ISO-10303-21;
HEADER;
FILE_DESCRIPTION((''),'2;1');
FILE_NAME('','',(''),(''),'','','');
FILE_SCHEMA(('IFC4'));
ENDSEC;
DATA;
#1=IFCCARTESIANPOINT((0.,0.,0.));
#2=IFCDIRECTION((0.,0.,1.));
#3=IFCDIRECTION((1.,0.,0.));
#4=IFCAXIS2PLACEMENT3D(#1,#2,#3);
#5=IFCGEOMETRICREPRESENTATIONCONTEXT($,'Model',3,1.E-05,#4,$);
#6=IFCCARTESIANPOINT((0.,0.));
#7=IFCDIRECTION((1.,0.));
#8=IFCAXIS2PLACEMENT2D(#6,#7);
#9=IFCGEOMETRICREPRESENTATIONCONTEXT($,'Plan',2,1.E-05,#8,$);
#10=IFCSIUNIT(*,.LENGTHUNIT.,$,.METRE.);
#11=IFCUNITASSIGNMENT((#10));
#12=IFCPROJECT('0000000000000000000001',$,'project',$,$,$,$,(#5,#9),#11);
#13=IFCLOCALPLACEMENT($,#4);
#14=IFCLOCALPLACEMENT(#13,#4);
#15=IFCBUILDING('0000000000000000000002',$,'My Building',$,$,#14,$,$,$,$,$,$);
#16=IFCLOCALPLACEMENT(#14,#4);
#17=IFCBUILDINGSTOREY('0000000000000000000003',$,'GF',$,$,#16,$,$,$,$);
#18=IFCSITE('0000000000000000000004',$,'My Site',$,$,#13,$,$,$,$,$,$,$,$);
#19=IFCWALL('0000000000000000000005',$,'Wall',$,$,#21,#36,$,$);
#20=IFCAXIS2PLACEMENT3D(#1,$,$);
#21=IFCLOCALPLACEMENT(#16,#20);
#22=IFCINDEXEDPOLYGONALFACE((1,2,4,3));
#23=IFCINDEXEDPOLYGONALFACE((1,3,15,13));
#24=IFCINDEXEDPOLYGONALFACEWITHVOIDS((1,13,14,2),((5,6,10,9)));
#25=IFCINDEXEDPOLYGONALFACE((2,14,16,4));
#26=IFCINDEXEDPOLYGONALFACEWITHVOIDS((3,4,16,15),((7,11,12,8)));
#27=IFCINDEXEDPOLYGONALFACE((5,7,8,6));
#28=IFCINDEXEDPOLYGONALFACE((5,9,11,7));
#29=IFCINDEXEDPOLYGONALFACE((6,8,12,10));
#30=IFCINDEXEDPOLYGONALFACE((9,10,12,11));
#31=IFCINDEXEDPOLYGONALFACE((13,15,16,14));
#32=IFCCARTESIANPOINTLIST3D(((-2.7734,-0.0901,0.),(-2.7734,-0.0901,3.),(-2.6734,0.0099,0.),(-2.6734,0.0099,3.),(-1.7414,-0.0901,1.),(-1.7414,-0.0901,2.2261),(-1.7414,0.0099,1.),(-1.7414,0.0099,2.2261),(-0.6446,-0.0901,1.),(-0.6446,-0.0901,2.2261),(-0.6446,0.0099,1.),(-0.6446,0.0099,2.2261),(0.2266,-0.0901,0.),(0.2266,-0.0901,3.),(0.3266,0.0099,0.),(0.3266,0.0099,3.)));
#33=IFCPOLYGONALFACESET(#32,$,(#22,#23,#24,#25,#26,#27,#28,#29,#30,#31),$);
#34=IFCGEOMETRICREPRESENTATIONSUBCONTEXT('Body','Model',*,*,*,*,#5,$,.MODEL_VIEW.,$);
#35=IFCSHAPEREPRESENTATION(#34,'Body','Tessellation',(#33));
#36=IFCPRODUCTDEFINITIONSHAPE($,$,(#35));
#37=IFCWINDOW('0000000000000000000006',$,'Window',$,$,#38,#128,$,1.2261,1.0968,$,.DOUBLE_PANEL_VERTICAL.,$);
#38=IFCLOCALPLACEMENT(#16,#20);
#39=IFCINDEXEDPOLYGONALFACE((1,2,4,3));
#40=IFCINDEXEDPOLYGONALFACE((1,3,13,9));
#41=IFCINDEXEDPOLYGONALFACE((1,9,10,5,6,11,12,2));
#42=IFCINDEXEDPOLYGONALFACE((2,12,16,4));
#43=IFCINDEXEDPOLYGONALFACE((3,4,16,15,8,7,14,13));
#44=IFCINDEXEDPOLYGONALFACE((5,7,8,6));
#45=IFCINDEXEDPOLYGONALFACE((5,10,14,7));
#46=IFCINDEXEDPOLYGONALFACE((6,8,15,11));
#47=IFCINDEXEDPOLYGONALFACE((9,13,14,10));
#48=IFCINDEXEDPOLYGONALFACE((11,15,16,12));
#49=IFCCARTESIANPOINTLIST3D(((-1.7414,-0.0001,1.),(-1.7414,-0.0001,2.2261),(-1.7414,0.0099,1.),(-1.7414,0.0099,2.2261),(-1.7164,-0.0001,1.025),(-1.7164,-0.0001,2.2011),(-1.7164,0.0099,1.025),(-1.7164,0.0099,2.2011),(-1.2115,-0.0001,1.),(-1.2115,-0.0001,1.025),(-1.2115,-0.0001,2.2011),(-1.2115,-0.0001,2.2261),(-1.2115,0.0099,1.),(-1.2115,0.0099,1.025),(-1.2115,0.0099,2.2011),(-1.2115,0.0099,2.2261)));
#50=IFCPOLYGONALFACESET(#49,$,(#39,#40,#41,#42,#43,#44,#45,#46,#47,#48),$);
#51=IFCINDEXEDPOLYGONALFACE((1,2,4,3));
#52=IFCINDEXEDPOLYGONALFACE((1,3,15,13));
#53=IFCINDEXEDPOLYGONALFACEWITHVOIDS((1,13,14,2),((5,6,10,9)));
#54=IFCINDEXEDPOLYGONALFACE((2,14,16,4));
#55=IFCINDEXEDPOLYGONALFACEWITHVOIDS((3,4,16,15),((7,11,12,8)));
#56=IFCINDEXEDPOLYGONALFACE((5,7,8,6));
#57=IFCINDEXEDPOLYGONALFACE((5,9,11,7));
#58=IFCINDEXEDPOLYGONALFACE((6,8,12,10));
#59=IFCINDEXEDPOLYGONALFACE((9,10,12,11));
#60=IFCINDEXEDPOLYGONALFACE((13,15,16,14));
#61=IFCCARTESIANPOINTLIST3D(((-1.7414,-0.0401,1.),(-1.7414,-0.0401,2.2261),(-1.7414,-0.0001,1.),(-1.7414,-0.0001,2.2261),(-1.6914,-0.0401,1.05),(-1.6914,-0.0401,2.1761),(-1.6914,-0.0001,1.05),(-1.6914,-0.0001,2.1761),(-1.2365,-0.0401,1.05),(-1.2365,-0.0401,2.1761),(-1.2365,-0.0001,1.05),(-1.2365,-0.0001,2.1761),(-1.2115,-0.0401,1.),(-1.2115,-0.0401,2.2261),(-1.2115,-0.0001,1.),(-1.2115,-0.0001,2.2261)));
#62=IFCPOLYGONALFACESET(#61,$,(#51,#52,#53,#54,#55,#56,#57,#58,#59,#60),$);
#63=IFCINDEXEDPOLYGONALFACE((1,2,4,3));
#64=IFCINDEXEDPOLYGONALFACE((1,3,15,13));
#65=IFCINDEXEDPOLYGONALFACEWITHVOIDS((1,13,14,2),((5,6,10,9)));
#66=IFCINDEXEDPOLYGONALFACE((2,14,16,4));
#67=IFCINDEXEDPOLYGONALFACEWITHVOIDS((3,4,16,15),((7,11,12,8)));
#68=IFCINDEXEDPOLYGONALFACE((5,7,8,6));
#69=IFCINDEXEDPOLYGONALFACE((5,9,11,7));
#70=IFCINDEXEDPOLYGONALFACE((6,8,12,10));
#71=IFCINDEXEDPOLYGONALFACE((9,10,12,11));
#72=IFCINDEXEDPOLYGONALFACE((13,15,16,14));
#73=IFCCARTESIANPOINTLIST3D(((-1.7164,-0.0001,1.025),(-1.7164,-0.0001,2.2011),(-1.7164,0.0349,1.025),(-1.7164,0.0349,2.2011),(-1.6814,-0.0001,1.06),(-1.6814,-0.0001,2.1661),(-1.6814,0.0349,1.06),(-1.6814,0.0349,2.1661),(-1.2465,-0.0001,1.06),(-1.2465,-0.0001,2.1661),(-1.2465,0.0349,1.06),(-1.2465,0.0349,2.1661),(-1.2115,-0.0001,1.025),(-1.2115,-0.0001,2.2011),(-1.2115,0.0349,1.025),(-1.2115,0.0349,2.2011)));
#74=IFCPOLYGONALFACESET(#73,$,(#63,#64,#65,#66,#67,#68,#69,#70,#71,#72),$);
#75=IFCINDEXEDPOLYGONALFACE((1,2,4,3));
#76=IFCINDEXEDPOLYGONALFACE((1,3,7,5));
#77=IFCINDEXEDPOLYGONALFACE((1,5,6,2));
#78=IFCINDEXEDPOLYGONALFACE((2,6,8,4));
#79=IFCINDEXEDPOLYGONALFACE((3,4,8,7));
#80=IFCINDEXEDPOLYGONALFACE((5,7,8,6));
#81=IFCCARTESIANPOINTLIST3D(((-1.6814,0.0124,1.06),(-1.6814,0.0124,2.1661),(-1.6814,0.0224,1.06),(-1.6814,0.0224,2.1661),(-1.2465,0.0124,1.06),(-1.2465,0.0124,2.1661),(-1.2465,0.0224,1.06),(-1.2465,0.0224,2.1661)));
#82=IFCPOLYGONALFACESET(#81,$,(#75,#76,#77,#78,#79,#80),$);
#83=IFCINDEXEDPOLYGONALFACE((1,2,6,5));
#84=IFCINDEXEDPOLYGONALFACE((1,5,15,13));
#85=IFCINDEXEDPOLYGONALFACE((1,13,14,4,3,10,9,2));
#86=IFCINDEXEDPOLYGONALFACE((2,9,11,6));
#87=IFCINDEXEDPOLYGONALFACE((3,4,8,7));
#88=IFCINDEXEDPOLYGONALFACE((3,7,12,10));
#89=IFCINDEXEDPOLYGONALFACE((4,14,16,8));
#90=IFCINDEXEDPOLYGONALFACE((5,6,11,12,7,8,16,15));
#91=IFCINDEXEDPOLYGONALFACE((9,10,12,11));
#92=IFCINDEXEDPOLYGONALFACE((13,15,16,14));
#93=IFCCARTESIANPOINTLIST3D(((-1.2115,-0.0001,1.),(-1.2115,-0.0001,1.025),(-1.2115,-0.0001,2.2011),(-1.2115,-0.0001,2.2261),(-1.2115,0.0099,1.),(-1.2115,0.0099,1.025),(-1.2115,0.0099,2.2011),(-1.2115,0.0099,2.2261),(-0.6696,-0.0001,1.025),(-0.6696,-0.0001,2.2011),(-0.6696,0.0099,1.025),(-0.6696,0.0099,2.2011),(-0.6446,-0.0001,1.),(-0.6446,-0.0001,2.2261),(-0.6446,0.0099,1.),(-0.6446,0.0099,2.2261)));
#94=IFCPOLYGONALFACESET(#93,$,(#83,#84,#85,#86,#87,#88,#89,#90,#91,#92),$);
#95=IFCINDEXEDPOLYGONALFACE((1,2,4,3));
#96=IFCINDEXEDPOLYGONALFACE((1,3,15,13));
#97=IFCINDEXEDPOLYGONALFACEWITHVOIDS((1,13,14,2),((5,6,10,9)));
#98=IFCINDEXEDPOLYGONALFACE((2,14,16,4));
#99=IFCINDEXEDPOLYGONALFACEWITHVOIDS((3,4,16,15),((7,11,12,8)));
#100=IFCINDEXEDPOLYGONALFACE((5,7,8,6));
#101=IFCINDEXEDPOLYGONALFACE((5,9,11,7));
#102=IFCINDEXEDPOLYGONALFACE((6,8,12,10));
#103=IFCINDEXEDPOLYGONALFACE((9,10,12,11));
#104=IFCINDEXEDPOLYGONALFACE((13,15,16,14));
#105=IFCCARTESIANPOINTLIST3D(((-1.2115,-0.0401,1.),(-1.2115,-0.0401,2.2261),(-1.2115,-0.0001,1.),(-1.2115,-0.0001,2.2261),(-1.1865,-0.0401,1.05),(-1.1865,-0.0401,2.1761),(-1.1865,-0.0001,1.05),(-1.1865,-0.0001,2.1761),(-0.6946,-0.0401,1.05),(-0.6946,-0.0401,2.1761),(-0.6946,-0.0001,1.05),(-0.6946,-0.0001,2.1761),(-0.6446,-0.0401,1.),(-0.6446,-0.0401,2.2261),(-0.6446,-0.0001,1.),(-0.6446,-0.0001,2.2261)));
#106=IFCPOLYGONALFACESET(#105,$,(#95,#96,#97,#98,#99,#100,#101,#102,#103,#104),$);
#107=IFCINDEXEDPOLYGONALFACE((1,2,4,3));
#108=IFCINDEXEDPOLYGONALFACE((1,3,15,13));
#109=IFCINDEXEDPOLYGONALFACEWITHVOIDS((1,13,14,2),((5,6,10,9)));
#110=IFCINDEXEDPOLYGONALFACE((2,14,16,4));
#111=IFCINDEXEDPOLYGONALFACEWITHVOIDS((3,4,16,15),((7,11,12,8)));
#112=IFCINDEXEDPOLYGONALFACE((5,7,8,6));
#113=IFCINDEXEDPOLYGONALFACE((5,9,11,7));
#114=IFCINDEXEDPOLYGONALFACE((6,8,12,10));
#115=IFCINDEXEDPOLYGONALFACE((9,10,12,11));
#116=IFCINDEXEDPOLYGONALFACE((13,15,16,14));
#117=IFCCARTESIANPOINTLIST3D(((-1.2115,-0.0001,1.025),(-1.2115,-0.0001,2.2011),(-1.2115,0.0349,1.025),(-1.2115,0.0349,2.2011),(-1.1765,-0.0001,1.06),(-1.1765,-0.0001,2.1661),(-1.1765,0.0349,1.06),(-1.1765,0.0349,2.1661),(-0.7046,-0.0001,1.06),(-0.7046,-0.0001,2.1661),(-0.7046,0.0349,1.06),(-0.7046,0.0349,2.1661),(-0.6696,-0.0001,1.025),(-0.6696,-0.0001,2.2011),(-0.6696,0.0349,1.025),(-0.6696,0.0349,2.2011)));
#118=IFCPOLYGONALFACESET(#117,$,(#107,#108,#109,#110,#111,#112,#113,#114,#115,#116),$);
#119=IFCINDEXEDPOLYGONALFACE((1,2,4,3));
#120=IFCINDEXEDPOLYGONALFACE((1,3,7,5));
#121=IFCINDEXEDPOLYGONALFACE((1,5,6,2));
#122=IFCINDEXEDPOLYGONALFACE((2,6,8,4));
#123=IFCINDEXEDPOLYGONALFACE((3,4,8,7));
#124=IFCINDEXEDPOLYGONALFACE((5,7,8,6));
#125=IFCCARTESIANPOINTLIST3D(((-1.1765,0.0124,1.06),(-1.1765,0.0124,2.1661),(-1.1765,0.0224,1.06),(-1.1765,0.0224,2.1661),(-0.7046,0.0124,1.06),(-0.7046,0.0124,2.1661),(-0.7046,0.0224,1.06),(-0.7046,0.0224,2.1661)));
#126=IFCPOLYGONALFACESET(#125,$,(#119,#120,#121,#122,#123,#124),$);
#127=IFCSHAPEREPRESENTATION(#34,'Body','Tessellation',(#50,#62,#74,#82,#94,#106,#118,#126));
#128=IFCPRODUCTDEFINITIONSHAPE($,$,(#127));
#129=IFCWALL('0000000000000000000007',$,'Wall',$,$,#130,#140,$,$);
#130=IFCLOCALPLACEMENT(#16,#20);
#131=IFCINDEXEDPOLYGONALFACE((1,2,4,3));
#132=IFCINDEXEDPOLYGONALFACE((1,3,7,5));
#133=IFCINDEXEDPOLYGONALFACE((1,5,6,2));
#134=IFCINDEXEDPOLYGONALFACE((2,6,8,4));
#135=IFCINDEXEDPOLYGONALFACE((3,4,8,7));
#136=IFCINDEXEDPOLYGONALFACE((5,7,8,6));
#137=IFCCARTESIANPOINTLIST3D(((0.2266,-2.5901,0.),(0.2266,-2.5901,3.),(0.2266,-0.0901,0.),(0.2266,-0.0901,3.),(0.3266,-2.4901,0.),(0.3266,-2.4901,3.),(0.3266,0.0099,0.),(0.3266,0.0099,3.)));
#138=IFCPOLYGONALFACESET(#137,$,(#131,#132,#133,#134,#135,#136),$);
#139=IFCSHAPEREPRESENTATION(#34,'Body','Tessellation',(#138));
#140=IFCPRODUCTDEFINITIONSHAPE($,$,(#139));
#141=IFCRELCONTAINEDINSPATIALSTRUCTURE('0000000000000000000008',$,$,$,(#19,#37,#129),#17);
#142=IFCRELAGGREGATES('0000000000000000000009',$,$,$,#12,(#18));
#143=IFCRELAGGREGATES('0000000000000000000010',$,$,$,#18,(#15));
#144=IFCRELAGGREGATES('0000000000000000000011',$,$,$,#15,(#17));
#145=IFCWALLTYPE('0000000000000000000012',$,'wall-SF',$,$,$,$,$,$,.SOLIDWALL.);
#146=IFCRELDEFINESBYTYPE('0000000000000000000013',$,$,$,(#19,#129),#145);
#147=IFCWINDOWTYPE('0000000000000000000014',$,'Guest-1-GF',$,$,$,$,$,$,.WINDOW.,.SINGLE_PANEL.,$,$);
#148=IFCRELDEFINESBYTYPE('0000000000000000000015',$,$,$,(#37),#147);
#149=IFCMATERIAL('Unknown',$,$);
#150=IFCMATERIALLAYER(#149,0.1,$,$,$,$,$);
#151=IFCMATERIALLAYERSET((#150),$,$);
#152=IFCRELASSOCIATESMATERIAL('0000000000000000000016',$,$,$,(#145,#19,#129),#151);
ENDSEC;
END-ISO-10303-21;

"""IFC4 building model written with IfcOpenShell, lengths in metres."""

from ifc_helpers import new_model, entity, si_unit, frame, origin_with_axes, origin_2d_with_axis, place, context, subcontext, project, spatial, line, indexed_curve, outline, extrude, shape, source, transform, mapped, material, layer, layer_set, layer_usage, type_object, type_shapes, element, fill, save


model = new_model("IFC4")

# Units and contexts
model_context = context("Model", 3, precision=1e-05, world=origin_with_axes())
plan_context = context("Plan", 2, precision=1e-05, world=origin_2d_with_axis())
body_context_1 = subcontext(model_context, "Body", "Model", "MODEL_VIEW")
body_context_2 = subcontext(plan_context, "Body", "Plan", "PLAN_VIEW")
ifc_project = project(units=[si_unit("LENGTHUNIT", "METRE")], contexts=[model_context, plan_context])

# Site, building, storey
site_placement = place(None, origin_with_axes())
site = spatial("IfcSite", under=ifc_project, at=site_placement, Name="My Site")
building_placement = place(site_placement, origin_with_axes())
building = spatial("IfcBuilding", under=site, at=building_placement, Name="My Building")
storey_placement = place(building_placement, origin_with_axes())
storey = spatial("IfcBuildingStorey", under=building, at=storey_placement, Name="GF")

# Shared definitions
ifc_material = material(Name="Unknown")

# Shared definitions
ifc_layer_1 = layer(ifc_material, 0.1)
ifc_layer_set_1 = layer_set([ifc_layer_1])
wall_type = type_object("IfcWallType", Name="wall-SF", PredefinedType="SOLIDWALL", material=ifc_layer_set_1)

# Wall, opening, window
ifc_layer_usage_1 = layer_usage(ifc_layer_set_1, "AXIS2", "POSITIVE", 0.0)
wall_1_placement = place(storey_placement, frame((-2.7734, -0.0901, 0.0), z_axis=(0.0, 0.0, 1.0), x_axis=(1.0, 0.0, 0.0)))
wall_1 = element("IfcWall", 1, at=wall_1_placement, inside=storey, type_object=wall_type, material=ifc_layer_usage_1, Name="Wall", context=body_context_1, shape_type="SweptSolid", body=[
    extrude(outline(indexed_curve([(0.0, 0.0), (0.1, 0.1), (3.1, 0.1), (3.0, 0.0)], segments=[line(1, 2, 3, 4, 1)])), origin_with_axes(), (0.0, 0.0, 1.0), 3.0),
])
shared_shape_1 = source(origin_with_axes(), body_context_1, "Body", "SweptSolid", [
    extrude(outline(indexed_curve([(0.0, 0.0), (1.0968, 0.0), (1.0968, 1.2261), (0.0, 1.2261)], segments=[line(1, 2, 3, 4, 1)])), frame((0.0, -0.6, 0.0), z_axis=(0.0, -1.0, 0.0), x_axis=(1.0, 0.0, 0.0)), (0.0, 0.0, -1.0), 1.2),
])
opening_1_placement = place(wall_1_placement, frame((1.032, 0.0, 1.0), z_axis=(0.0, 0.0, 1.0), x_axis=(1.0, 0.0, 0.0)))
opening_1 = element("IfcOpeningElement", 2, at=opening_1_placement, cuts=wall_1, PredefinedType="OPENING", context=body_context_1, shape_type="MappedRepresentation", body=[
    mapped(shared_shape_1, transform((0.0, 0.0, 0.0), x_axis=(1.0, 0.0, 0.0), y_axis=(0.0, 1.0, 0.0), z_axis=(0.0, 0.0, 1.0), scale=1.0)),
])
window_type_1 = type_object("IfcWindowType", Name="Guest-1-GF", PartitioningType="SINGLE_PANEL", PredefinedType="WINDOW")
shared_shape_2 = source(origin_with_axes(), body_context_1, "Body", "SweptSolid", [
    extrude(outline(indexed_curve([(0.5299, 0.0), (0.0, 0.0), (0.0, 1.2261), (0.5299, 1.2261), (0.5299, 1.2011), (0.025, 1.2011), (0.025, 0.025), (0.5299, 0.025)], segments=[line(1, 2, 3, 4, 5, 6, 7, 8, 1)])), frame((0.0, 0.09, 0.0), z_axis=(0.0, -1.0, 0.0), x_axis=(1.0, 0.0, 0.0)), (0.0, 0.0, -1.0), 0.01),
    extrude(outline(indexed_curve([(0.0, 0.0), (0.5299, 0.0), (0.5299, 1.2261), (0.0, 1.2261)], segments=[line(1, 2, 3, 4, 1)]), holes=[indexed_curve([(0.05, 0.05), (0.5049, 0.05), (0.5049, 1.1761), (0.05, 1.1761)], segments=[line(1, 2, 3, 4, 1)])]), frame((0.0, 0.05, 0.0), z_axis=(0.0, -1.0, 0.0), x_axis=(1.0, 0.0, 0.0)), (0.0, 0.0, -1.0), 0.04),
    extrude(outline(indexed_curve([(0.0, 0.0), (0.5049, 0.0), (0.5049, 1.1761), (0.0, 1.1761)], segments=[line(1, 2, 3, 4, 1)]), holes=[indexed_curve([(0.035, 0.035), (0.4699, 0.035), (0.4699, 1.1411), (0.035, 1.1411)], segments=[line(1, 2, 3, 4, 1)])]), frame((0.025, 0.09, 0.025), z_axis=(0.0, -1.0, 0.0), x_axis=(1.0, 0.0, 0.0)), (0.0, 0.0, -1.0), 0.035),
    extrude(outline(indexed_curve([(0.035, 0.035), (0.4699, 0.035), (0.4699, 1.1411), (0.035, 1.1411)], segments=[line(1, 2, 3, 4, 1)])), frame((0.025, 0.1025, 0.025), z_axis=(0.0, -1.0, 0.0), x_axis=(1.0, 0.0, 0.0)), (0.0, 0.0, -1.0), 0.01),
    extrude(outline(indexed_curve([(0.0, 1.2261), (0.5669, 1.2261), (0.5669, 0.0), (0.0, 0.0), (0.0, 0.025), (0.5419, 0.025), (0.5419, 1.2011), (0.0, 1.2011)], segments=[line(1, 2, 3, 4, 5, 6, 7, 8, 1)])), frame((0.5299, 0.09, 0.0), z_axis=(0.0, -1.0, 0.0), x_axis=(1.0, 0.0, 0.0)), (0.0, 0.0, -1.0), 0.01),
    extrude(outline(indexed_curve([(0.0, 0.0), (0.5669, 0.0), (0.5669, 1.2261), (0.0, 1.2261)], segments=[line(1, 2, 3, 4, 1)]), holes=[indexed_curve([(0.025, 0.05), (0.5169, 0.05), (0.5169, 1.1761), (0.025, 1.1761)], segments=[line(1, 2, 3, 4, 1)])]), frame((0.5299, 0.05, 0.0), z_axis=(0.0, -1.0, 0.0), x_axis=(1.0, 0.0, 0.0)), (0.0, 0.0, -1.0), 0.04),
    extrude(outline(indexed_curve([(0.0, 0.0), (0.5419, 0.0), (0.5419, 1.1761), (0.0, 1.1761)], segments=[line(1, 2, 3, 4, 1)]), holes=[indexed_curve([(0.035, 0.035), (0.5069, 0.035), (0.5069, 1.1411), (0.035, 1.1411)], segments=[line(1, 2, 3, 4, 1)])]), frame((0.5299, 0.09, 0.025), z_axis=(0.0, -1.0, 0.0), x_axis=(1.0, 0.0, 0.0)), (0.0, 0.0, -1.0), 0.035),
    extrude(outline(indexed_curve([(0.035, 0.035), (0.5069, 0.035), (0.5069, 1.1411), (0.035, 1.1411)], segments=[line(1, 2, 3, 4, 1)])), frame((0.5299, 0.1025, 0.025), z_axis=(0.0, -1.0, 0.0), x_axis=(1.0, 0.0, 0.0)), (0.0, 0.0, -1.0), 0.01),
])
shared_shape_3 = source(origin_with_axes(), body_context_2, "Body", "Curve2D", [
    entity("IfcIndexedPolyCurve", entity("IfcCartesianPointList2D", [[0.05, 0.05], [0.5049, 0.05]])),
    entity("IfcIndexedPolyCurve", entity("IfcCartesianPointList2D", [[0.0, 0.1], [0.025, 0.1], [0.025, 0.09], [0.05, 0.09], [0.05, 0.05], [0.0, 0.05]]), [entity("IfcLineIndex", [1, 2, 3, 4, 5, 6, 1])]),
    entity("IfcIndexedPolyCurve", entity("IfcCartesianPointList2D", [[0.5299, 0.1], [0.5299, 0.1], [0.5299, 0.09], [0.5049, 0.09], [0.5049, 0.05], [0.5299, 0.05]])),
    entity("IfcIndexedPolyCurve", entity("IfcCartesianPointList2D", [[0.025, 0.09], [0.06, 0.09], [0.06, 0.125], [0.025, 0.125]]), [entity("IfcLineIndex", [1, 2, 3, 4, 1])]),
    entity("IfcIndexedPolyCurve", entity("IfcCartesianPointList2D", [[0.5299, 0.09], [0.4949, 0.09], [0.4949, 0.125], [0.5299, 0.125]]), [entity("IfcLineIndex", [1, 2, 3, 4, 1])]),
    entity("IfcIndexedPolyCurve", entity("IfcCartesianPointList2D", [[0.06, 0.09], [0.4949, 0.09]])),
    entity("IfcIndexedPolyCurve", entity("IfcCartesianPointList2D", [[0.06, 0.125], [0.4949, 0.125]])),
    entity("IfcIndexedPolyCurve", entity("IfcCartesianPointList2D", [[0.06, 0.1075], [0.4949, 0.1075]])),
    entity("IfcIndexedPolyCurve", entity("IfcCartesianPointList2D", [[0.5549, 0.05], [1.0468, 0.05]])),
    entity("IfcIndexedPolyCurve", entity("IfcCartesianPointList2D", [[0.5299, 0.1], [0.5299, 0.1], [0.5299, 0.09], [0.5549, 0.09], [0.5549, 0.05], [0.5299, 0.05]])),
    entity("IfcIndexedPolyCurve", entity("IfcCartesianPointList2D", [[1.0968, 0.1], [1.0718, 0.1], [1.0718, 0.09], [1.0468, 0.09], [1.0468, 0.05], [1.0968, 0.05]]), [entity("IfcLineIndex", [1, 2, 3, 4, 5, 6, 1])]),
    entity("IfcIndexedPolyCurve", entity("IfcCartesianPointList2D", [[0.5299, 0.09], [0.5649, 0.09], [0.5649, 0.125], [0.5299, 0.125]]), [entity("IfcLineIndex", [1, 2, 3, 4, 1])]),
    entity("IfcIndexedPolyCurve", entity("IfcCartesianPointList2D", [[1.0718, 0.09], [1.0368, 0.09], [1.0368, 0.125], [1.0718, 0.125]]), [entity("IfcLineIndex", [1, 2, 3, 4, 1])]),
    entity("IfcIndexedPolyCurve", entity("IfcCartesianPointList2D", [[0.5649, 0.09], [1.0368, 0.09]])),
    entity("IfcIndexedPolyCurve", entity("IfcCartesianPointList2D", [[0.5649, 0.125], [1.0368, 0.125]])),
    entity("IfcIndexedPolyCurve", entity("IfcCartesianPointList2D", [[0.5649, 0.1075], [1.0368, 0.1075]])),
])
type_shapes(window_type_1, [shared_shape_2, shared_shape_3])
window_1_placement = place(opening_1_placement, origin_with_axes())
window_1 = element("IfcWindow", 3, at=window_1_placement, inside=storey, type_object=window_type_1, Name="Window", OverallHeight=1.2261, OverallWidth=1.0968, PartitioningType="DOUBLE_PANEL_VERTICAL", shapes=[
    shape(body_context_1, "Body", "MappedRepresentation", [mapped(shared_shape_2, transform((0.0, 0.0, 0.0), x_axis=(1.0, 0.0, 0.0), y_axis=(0.0, 1.0, 0.0), z_axis=(0.0, 0.0, 1.0), scale=1.0))]),
    shape(body_context_2, "Body", "MappedRepresentation", [mapped(shared_shape_3, transform((0.0, 0.0, 0.0), x_axis=(1.0, 0.0, 0.0), y_axis=(0.0, 1.0, 0.0), z_axis=(0.0, 0.0, 1.0), scale=1.0))]),
])
fill(opening_1, window_1)

# Wall
ifc_layer_usage_2 = layer_usage(ifc_layer_set_1, "AXIS2", "POSITIVE", 0.0)
wall_2_placement = place(storey_placement, frame((0.2266, -0.0901, 0.0), z_axis=(0.0, 0.0, 1.0), x_axis=(-0.000001, -1.0, 0.0)))
element("IfcWall", 4, at=wall_2_placement, inside=storey, type_object=wall_type, material=ifc_layer_usage_2, Name="Wall", context=body_context_1, shape_type="SweptSolid", body=[
    extrude(outline(indexed_curve([(0.0, 0.0), (-0.1, 0.1), (2.4, 0.1), (2.5, 0.0)], segments=[line(1, 2, 3, 4, 1)])), origin_with_axes(), (0.0, 0.0, 1.0), 3.0),
])

save(model, "model.ifc")
